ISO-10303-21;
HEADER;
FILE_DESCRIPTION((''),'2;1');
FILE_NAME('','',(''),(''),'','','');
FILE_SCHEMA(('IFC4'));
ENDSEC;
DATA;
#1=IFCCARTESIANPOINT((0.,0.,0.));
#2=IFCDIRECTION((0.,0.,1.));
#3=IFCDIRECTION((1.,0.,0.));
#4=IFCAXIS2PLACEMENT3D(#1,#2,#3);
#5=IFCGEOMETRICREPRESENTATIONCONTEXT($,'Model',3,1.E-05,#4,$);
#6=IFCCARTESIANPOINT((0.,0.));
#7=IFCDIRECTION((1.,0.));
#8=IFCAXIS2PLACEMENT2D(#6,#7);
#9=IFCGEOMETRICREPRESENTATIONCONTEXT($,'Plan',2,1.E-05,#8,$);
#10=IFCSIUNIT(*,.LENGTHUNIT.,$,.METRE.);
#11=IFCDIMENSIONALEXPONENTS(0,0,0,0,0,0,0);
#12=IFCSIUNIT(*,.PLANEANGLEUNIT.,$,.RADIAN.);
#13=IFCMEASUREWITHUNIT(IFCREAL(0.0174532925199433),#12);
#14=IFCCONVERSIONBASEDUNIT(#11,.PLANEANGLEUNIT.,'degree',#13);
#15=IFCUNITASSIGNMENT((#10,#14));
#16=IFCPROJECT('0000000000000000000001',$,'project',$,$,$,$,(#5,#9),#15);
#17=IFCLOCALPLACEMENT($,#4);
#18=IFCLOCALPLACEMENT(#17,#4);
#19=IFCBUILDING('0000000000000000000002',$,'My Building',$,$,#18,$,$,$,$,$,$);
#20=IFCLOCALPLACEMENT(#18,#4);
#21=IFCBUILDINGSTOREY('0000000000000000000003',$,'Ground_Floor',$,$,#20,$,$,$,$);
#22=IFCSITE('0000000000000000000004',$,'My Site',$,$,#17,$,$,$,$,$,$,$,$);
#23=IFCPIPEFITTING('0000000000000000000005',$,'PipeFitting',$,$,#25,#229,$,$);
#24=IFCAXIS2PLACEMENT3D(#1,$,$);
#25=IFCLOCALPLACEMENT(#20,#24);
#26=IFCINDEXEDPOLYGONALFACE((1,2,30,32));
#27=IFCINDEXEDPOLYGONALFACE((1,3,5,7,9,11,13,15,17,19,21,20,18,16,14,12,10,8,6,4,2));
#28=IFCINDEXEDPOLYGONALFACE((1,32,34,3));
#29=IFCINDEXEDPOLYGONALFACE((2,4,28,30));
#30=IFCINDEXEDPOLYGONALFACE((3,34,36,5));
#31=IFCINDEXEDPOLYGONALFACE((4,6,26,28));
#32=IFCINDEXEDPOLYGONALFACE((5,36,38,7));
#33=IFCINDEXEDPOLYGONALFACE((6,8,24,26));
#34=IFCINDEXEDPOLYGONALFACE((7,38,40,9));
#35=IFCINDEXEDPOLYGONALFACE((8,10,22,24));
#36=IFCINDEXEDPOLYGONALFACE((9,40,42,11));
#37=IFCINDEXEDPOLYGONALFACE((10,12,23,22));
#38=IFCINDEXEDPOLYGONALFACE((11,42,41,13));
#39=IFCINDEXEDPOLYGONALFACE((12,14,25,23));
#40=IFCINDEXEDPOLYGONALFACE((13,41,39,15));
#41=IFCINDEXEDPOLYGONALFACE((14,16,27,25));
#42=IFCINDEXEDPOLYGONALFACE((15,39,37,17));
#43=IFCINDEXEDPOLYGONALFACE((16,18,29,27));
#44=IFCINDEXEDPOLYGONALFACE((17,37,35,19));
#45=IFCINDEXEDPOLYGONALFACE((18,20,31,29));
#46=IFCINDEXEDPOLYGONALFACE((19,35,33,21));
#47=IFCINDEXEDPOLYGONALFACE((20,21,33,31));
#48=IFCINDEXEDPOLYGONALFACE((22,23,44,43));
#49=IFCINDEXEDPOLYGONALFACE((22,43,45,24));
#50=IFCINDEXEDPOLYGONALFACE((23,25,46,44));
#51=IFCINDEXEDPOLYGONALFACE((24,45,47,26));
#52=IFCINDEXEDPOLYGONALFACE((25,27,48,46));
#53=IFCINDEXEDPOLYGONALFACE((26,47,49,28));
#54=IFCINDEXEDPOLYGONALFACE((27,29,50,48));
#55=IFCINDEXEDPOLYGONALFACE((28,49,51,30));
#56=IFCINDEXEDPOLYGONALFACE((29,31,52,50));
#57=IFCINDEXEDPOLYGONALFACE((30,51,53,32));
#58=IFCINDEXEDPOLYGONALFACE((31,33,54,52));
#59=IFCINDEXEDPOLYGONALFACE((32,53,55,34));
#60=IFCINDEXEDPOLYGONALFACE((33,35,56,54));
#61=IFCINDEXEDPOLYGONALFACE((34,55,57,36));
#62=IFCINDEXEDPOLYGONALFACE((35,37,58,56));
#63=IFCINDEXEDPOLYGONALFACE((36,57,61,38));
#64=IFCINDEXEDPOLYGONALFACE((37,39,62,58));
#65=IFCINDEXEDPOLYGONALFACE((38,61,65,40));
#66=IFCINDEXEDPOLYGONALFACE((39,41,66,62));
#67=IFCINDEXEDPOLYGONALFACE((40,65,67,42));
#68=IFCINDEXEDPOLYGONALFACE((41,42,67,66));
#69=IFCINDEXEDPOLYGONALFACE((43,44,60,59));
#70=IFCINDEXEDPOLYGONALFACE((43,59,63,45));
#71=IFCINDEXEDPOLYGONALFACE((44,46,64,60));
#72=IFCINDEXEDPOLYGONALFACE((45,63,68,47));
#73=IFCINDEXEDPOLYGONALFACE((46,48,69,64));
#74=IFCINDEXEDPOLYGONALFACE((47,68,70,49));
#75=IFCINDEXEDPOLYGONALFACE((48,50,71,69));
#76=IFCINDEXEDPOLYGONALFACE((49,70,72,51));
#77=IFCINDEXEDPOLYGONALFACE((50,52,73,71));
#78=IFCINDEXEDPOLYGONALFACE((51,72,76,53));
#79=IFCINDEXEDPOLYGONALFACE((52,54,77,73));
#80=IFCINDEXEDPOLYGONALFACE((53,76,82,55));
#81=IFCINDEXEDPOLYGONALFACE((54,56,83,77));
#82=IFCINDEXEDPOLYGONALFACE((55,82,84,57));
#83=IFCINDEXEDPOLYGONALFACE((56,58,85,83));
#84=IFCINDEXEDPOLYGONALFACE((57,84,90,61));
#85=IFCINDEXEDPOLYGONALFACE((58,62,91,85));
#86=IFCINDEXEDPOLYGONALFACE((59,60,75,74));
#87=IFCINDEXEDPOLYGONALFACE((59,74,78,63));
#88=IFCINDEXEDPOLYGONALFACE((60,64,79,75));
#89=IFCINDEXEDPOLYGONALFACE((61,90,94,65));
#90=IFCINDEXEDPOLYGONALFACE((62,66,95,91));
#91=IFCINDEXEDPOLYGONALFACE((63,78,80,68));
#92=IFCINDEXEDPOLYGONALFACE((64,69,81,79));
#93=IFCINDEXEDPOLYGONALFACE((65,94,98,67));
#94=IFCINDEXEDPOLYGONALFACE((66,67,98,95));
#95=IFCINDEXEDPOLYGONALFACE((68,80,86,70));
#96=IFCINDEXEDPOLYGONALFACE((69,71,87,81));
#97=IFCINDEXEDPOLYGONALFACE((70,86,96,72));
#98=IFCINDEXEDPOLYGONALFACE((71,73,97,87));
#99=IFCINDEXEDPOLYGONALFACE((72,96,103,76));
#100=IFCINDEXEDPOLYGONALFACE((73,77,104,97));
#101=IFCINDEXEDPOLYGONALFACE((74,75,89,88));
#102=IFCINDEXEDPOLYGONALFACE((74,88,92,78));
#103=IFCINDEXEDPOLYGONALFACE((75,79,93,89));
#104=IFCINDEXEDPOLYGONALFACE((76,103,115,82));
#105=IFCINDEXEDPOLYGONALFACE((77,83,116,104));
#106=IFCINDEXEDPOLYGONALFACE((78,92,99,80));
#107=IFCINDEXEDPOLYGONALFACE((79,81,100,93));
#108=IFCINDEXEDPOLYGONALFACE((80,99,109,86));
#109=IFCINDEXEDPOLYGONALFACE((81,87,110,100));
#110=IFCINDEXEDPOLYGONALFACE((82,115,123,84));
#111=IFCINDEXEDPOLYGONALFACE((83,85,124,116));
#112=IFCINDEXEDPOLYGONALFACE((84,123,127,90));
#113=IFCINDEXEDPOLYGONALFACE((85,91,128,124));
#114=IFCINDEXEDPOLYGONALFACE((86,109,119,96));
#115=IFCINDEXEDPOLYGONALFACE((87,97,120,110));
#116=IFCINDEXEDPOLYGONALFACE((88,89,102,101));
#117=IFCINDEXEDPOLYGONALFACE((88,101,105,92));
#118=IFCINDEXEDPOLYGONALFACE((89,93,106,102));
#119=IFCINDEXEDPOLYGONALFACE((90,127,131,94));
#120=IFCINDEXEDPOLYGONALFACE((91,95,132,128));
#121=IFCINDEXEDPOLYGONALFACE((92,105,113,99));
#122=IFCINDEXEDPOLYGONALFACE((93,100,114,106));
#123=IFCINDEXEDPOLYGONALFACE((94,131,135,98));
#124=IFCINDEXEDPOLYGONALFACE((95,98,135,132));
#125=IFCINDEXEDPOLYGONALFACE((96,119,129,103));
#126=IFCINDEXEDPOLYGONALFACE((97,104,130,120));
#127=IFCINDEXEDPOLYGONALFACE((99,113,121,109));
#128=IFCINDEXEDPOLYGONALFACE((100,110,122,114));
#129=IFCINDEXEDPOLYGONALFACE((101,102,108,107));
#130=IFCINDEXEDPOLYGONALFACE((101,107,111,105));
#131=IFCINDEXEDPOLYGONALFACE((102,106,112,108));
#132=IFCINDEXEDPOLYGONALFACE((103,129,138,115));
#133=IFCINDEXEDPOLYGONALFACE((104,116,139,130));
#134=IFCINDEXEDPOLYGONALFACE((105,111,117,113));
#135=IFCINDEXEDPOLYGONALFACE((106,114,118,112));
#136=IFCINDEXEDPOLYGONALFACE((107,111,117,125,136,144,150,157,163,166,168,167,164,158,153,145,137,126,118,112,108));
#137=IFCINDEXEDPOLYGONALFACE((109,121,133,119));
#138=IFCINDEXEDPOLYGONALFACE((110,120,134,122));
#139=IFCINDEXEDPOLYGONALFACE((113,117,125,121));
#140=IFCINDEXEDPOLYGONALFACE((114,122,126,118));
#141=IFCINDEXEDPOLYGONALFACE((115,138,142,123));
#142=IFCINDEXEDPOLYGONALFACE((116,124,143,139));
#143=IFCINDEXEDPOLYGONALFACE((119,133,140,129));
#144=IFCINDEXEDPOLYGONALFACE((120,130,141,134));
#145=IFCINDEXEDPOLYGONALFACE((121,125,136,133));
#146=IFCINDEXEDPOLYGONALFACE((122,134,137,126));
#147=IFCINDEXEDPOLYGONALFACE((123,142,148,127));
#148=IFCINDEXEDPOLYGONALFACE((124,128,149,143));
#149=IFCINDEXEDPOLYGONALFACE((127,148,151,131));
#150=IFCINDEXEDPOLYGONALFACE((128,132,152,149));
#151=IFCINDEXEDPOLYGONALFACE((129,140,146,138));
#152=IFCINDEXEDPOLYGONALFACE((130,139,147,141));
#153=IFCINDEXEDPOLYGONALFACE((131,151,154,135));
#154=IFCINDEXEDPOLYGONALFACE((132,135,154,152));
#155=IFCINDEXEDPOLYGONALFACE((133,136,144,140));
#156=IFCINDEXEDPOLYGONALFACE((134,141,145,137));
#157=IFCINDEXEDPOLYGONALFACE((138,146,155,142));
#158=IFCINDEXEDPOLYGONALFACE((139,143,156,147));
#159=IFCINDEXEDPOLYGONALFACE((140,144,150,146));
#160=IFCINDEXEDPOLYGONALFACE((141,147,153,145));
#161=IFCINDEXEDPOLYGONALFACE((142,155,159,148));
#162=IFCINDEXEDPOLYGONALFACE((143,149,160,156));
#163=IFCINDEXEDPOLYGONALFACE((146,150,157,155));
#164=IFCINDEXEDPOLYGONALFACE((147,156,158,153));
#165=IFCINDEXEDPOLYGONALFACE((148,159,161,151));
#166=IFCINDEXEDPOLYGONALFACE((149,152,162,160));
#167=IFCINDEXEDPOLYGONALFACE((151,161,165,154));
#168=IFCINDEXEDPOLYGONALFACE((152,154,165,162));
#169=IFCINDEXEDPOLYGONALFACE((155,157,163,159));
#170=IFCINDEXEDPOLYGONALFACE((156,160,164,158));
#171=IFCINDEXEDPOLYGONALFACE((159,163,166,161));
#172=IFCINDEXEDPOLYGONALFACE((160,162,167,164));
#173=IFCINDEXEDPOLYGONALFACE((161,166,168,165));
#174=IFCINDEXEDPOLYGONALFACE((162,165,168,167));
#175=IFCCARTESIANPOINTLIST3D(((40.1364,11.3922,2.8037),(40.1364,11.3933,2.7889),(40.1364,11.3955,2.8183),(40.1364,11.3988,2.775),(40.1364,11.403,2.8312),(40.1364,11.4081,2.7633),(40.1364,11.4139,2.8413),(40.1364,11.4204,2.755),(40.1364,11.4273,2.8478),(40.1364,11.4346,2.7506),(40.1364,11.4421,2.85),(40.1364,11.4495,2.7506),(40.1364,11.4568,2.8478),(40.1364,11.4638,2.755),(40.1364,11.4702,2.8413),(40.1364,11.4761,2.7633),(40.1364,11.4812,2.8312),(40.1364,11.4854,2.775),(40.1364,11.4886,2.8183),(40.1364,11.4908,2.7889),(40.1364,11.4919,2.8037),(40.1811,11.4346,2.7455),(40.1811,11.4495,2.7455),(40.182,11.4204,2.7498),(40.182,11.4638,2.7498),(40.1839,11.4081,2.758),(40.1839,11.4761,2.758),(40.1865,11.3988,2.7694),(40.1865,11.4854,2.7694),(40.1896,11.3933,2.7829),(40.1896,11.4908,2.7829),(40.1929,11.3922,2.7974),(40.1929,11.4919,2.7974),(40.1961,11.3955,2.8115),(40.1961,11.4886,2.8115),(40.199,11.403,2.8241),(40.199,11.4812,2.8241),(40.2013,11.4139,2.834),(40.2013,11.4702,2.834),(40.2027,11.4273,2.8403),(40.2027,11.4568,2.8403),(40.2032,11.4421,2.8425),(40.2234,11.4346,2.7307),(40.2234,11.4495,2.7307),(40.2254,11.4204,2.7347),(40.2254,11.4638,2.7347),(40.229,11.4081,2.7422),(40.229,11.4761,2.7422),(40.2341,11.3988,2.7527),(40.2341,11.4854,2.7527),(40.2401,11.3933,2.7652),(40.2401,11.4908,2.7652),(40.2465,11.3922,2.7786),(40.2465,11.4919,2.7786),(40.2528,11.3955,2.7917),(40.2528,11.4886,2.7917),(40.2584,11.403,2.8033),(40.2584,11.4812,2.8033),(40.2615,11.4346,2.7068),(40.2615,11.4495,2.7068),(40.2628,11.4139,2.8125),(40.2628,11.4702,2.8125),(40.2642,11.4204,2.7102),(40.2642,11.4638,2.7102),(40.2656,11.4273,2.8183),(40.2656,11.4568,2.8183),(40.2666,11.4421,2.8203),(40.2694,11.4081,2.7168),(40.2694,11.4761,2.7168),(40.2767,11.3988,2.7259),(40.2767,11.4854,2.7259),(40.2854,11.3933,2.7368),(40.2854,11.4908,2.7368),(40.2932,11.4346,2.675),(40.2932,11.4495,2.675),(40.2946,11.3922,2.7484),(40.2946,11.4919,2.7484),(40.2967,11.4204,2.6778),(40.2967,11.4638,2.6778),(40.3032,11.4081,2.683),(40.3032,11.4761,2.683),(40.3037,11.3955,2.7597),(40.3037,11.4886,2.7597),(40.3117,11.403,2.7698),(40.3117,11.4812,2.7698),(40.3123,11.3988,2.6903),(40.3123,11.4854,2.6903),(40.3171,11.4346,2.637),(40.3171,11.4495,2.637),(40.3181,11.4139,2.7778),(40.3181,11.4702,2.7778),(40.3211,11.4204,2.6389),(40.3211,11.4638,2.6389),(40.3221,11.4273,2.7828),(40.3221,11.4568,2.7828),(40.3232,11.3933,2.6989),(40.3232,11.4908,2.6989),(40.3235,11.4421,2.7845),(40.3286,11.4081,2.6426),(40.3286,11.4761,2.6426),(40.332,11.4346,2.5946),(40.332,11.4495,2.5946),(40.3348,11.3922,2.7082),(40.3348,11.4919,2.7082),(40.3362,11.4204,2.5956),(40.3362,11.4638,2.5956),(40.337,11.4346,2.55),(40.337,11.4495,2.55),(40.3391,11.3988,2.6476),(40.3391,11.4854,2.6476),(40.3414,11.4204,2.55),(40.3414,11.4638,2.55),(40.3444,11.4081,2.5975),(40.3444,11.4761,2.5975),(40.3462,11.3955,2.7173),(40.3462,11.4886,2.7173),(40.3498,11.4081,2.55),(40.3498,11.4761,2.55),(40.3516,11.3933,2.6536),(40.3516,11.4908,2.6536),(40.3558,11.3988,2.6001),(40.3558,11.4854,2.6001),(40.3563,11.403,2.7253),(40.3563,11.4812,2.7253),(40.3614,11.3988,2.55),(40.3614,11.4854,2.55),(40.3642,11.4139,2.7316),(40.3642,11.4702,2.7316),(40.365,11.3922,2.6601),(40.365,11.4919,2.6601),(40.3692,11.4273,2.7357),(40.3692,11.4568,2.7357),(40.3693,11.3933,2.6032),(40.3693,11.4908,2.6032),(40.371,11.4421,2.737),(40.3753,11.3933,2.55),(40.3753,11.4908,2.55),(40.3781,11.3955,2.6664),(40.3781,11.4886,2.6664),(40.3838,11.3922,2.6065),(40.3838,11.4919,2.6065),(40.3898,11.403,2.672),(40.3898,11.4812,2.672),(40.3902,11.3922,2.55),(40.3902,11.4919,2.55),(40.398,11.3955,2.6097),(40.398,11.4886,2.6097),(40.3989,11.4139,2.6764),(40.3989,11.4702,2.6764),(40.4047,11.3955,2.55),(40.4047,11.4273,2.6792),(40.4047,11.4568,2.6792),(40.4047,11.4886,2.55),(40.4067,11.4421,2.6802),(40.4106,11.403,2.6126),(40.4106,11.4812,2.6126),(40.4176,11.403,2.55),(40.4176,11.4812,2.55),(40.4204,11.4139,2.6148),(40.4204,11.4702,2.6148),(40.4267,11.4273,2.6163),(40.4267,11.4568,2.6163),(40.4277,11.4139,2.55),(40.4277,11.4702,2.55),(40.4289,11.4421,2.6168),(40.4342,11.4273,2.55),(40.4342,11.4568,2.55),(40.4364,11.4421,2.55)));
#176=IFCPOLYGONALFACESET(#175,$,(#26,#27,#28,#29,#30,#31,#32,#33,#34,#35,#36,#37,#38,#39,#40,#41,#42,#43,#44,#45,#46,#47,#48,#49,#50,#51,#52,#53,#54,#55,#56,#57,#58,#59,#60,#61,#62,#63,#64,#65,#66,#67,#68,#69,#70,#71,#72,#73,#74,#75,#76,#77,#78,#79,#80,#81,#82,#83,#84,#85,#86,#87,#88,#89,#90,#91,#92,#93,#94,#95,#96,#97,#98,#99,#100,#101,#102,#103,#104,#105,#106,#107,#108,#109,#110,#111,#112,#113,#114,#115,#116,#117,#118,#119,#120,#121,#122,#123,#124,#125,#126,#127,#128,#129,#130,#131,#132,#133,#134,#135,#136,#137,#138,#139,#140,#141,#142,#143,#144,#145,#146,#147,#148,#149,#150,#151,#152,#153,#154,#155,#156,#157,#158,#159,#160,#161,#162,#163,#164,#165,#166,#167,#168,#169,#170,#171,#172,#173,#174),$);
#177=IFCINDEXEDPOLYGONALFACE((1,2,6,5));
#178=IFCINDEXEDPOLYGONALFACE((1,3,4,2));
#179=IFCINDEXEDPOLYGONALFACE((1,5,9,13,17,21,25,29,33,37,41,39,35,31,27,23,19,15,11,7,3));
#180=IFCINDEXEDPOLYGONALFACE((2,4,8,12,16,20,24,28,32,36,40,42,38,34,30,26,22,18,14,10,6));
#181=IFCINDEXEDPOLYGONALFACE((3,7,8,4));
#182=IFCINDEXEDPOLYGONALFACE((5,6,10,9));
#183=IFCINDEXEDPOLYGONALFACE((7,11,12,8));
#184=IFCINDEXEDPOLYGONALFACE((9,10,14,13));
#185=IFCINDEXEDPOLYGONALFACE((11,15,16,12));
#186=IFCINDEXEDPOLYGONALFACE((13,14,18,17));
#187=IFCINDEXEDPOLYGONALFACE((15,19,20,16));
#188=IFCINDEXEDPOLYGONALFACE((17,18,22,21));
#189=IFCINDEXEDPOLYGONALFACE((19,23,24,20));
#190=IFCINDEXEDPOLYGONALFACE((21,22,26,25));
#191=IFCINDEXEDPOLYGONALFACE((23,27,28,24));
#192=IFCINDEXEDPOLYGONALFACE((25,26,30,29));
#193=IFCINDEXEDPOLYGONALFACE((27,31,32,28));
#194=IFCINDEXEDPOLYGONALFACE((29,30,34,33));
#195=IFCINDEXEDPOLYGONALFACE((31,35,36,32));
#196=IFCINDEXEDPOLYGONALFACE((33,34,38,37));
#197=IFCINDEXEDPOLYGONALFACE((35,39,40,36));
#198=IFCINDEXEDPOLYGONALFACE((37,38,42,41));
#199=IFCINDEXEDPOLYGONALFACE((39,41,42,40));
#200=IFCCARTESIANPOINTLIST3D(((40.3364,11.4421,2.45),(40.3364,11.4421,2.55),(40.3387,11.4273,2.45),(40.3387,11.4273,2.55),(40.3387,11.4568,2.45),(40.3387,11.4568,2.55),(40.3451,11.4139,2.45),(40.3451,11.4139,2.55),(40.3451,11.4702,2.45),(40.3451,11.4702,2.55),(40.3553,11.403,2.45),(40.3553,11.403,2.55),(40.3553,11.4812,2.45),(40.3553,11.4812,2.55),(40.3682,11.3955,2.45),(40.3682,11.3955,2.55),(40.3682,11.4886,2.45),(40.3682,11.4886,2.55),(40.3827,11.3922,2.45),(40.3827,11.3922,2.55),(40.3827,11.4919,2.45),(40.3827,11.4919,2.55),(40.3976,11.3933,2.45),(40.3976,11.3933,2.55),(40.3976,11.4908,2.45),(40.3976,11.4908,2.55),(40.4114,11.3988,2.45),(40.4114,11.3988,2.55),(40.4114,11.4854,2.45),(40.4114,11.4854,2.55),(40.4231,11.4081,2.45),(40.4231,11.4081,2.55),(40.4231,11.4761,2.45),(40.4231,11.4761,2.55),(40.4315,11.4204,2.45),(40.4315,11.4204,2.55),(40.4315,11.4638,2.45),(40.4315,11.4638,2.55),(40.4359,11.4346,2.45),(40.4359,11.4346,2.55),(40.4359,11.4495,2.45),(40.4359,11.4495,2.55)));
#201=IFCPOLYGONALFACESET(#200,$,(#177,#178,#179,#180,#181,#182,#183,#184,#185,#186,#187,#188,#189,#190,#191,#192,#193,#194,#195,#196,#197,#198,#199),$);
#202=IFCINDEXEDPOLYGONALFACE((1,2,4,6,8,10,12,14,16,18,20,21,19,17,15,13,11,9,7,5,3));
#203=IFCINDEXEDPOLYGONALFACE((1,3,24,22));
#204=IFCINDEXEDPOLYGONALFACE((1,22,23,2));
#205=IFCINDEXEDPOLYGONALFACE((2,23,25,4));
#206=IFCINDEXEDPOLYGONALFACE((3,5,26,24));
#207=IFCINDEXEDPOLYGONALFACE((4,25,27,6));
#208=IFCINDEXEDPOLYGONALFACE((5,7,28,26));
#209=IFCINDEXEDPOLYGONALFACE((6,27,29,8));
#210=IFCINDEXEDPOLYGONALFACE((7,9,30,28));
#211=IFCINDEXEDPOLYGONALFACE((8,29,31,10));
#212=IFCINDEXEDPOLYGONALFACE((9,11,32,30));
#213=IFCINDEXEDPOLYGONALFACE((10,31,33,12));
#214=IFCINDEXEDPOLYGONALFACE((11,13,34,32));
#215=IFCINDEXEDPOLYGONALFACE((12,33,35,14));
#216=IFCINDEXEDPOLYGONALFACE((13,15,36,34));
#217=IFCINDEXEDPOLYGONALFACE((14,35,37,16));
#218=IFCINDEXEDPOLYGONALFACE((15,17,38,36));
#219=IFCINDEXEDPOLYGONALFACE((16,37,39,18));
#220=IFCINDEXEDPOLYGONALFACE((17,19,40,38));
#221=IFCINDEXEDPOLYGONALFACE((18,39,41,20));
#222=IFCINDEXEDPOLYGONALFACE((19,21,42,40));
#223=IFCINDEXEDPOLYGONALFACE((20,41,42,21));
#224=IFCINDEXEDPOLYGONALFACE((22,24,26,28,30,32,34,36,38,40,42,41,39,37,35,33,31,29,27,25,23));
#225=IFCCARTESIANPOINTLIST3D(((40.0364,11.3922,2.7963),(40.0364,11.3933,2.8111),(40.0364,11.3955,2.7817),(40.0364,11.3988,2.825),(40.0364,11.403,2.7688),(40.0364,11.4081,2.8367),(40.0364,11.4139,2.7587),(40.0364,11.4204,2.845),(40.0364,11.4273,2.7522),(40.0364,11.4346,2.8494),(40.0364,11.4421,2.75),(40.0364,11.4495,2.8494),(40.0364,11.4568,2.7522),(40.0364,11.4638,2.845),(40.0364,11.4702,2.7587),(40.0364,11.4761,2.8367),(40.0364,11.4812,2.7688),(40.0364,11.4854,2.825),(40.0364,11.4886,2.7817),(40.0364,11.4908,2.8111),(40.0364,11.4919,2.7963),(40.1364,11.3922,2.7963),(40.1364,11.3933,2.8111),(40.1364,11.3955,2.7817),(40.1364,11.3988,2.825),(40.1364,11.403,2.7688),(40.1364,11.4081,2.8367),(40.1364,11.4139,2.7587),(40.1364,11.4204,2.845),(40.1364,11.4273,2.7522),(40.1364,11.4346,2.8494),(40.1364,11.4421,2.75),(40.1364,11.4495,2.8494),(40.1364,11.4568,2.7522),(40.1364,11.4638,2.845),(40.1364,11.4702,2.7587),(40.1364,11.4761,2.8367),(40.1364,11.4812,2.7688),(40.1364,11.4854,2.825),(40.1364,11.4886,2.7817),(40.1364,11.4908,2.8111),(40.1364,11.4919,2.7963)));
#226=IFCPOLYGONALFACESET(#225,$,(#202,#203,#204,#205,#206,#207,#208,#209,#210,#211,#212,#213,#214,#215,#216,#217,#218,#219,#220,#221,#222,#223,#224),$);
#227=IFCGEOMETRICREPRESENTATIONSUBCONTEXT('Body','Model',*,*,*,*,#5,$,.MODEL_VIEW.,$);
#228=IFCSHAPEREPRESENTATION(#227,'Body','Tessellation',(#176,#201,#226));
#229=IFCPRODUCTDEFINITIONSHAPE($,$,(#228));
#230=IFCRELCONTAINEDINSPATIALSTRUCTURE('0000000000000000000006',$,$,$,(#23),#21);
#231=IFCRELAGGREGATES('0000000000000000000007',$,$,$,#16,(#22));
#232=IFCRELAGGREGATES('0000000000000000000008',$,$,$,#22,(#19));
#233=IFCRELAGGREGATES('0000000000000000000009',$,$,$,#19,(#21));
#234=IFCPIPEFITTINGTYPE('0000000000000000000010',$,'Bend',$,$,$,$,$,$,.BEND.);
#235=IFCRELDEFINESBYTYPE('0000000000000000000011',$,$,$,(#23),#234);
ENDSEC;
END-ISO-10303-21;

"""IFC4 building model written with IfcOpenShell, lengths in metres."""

from ifc_helpers import new_model, entity, si_unit, converted_unit, frame, origin_with_axes, origin_2d_with_axis, place, context, subcontext, project, spatial, circle, extrude, source, transform, mapped, type_object, type_shapes, element, save


model = new_model("IFC4")

# Units and contexts
model_context = context("Model", 3, precision=1e-05, world=origin_with_axes())
plan_context = context("Plan", 2, precision=1e-05, world=origin_2d_with_axis())
body_context = subcontext(model_context, "Body", "Model", "MODEL_VIEW")
ifc_project = project(units=[si_unit("LENGTHUNIT", "METRE"), converted_unit("PLANEANGLEUNIT", "degree", entity("IfcReal", 0.0174532925199433), si_unit("PLANEANGLEUNIT", "RADIAN"), dimensions=[0, 0, 0, 0, 0, 0, 0])], contexts=[model_context, plan_context])

# Site, building, storey
site_placement = place(None, origin_with_axes())
site = spatial("IfcSite", under=ifc_project, at=site_placement, Name="My Site")
building_placement = place(site_placement, origin_with_axes())
building = spatial("IfcBuilding", under=site, at=building_placement, Name="My Building")
storey_placement = place(building_placement, origin_with_axes())
storey = spatial("IfcBuildingStorey", under=building, at=storey_placement, Name="Ground_Floor")

# Pipe fitting
pipe_fitting_type = type_object("IfcPipeFittingType", Name="Bend", PredefinedType="BEND")
shared_shape = source(origin_with_axes(), body_context, "Body", "SolidModel", [
    entity("IfcSweptDiskSolid", entity("IfcIndexedPolyCurve", entity("IfcCartesianPointList3D", [[0.0, 0.0, -0.1], [0.0732, 0.0, -0.2768], [0.25, 0.0, -0.35]]), [entity("IfcArcIndex", [1, 2, 3])]), 0.05),
    extrude(circle(Radius=0.05), origin_with_axes(), (0.0, 0.0, -1.0), 0.1),
    extrude(circle(Radius=0.05), frame((0.25, 0.0, -0.35), z_axis=(1.0, 0.0, 0.0), x_axis=(0.0, 0.0, 1.0)), (0.0, 0.0, 1.0), 0.1),
])
type_shapes(pipe_fitting_type, [shared_shape])
for number, where, z_axis, x_axis, name in (
    (1, (40.3864, 11.4421, 2.45), (0.0, -0.000001, -1.0), (-1.0, 0.000001, 0.0), "PipeFitting"),
):
    element("IfcPipeFitting", number, at=place(storey_placement, frame(where, z_axis=z_axis, x_axis=x_axis)), inside=storey, type_object=pipe_fitting_type, Name=name, context=body_context, shape_type="MappedRepresentation", body=[
        mapped(shared_shape, transform((0.0, 0.0, 0.0), x_axis=(1.0, 0.0, 0.0), y_axis=(0.0, 1.0, 0.0), z_axis=(0.0, 0.0, 1.0), scale=1.0)),
    ])

save(model, "model.ifc")
